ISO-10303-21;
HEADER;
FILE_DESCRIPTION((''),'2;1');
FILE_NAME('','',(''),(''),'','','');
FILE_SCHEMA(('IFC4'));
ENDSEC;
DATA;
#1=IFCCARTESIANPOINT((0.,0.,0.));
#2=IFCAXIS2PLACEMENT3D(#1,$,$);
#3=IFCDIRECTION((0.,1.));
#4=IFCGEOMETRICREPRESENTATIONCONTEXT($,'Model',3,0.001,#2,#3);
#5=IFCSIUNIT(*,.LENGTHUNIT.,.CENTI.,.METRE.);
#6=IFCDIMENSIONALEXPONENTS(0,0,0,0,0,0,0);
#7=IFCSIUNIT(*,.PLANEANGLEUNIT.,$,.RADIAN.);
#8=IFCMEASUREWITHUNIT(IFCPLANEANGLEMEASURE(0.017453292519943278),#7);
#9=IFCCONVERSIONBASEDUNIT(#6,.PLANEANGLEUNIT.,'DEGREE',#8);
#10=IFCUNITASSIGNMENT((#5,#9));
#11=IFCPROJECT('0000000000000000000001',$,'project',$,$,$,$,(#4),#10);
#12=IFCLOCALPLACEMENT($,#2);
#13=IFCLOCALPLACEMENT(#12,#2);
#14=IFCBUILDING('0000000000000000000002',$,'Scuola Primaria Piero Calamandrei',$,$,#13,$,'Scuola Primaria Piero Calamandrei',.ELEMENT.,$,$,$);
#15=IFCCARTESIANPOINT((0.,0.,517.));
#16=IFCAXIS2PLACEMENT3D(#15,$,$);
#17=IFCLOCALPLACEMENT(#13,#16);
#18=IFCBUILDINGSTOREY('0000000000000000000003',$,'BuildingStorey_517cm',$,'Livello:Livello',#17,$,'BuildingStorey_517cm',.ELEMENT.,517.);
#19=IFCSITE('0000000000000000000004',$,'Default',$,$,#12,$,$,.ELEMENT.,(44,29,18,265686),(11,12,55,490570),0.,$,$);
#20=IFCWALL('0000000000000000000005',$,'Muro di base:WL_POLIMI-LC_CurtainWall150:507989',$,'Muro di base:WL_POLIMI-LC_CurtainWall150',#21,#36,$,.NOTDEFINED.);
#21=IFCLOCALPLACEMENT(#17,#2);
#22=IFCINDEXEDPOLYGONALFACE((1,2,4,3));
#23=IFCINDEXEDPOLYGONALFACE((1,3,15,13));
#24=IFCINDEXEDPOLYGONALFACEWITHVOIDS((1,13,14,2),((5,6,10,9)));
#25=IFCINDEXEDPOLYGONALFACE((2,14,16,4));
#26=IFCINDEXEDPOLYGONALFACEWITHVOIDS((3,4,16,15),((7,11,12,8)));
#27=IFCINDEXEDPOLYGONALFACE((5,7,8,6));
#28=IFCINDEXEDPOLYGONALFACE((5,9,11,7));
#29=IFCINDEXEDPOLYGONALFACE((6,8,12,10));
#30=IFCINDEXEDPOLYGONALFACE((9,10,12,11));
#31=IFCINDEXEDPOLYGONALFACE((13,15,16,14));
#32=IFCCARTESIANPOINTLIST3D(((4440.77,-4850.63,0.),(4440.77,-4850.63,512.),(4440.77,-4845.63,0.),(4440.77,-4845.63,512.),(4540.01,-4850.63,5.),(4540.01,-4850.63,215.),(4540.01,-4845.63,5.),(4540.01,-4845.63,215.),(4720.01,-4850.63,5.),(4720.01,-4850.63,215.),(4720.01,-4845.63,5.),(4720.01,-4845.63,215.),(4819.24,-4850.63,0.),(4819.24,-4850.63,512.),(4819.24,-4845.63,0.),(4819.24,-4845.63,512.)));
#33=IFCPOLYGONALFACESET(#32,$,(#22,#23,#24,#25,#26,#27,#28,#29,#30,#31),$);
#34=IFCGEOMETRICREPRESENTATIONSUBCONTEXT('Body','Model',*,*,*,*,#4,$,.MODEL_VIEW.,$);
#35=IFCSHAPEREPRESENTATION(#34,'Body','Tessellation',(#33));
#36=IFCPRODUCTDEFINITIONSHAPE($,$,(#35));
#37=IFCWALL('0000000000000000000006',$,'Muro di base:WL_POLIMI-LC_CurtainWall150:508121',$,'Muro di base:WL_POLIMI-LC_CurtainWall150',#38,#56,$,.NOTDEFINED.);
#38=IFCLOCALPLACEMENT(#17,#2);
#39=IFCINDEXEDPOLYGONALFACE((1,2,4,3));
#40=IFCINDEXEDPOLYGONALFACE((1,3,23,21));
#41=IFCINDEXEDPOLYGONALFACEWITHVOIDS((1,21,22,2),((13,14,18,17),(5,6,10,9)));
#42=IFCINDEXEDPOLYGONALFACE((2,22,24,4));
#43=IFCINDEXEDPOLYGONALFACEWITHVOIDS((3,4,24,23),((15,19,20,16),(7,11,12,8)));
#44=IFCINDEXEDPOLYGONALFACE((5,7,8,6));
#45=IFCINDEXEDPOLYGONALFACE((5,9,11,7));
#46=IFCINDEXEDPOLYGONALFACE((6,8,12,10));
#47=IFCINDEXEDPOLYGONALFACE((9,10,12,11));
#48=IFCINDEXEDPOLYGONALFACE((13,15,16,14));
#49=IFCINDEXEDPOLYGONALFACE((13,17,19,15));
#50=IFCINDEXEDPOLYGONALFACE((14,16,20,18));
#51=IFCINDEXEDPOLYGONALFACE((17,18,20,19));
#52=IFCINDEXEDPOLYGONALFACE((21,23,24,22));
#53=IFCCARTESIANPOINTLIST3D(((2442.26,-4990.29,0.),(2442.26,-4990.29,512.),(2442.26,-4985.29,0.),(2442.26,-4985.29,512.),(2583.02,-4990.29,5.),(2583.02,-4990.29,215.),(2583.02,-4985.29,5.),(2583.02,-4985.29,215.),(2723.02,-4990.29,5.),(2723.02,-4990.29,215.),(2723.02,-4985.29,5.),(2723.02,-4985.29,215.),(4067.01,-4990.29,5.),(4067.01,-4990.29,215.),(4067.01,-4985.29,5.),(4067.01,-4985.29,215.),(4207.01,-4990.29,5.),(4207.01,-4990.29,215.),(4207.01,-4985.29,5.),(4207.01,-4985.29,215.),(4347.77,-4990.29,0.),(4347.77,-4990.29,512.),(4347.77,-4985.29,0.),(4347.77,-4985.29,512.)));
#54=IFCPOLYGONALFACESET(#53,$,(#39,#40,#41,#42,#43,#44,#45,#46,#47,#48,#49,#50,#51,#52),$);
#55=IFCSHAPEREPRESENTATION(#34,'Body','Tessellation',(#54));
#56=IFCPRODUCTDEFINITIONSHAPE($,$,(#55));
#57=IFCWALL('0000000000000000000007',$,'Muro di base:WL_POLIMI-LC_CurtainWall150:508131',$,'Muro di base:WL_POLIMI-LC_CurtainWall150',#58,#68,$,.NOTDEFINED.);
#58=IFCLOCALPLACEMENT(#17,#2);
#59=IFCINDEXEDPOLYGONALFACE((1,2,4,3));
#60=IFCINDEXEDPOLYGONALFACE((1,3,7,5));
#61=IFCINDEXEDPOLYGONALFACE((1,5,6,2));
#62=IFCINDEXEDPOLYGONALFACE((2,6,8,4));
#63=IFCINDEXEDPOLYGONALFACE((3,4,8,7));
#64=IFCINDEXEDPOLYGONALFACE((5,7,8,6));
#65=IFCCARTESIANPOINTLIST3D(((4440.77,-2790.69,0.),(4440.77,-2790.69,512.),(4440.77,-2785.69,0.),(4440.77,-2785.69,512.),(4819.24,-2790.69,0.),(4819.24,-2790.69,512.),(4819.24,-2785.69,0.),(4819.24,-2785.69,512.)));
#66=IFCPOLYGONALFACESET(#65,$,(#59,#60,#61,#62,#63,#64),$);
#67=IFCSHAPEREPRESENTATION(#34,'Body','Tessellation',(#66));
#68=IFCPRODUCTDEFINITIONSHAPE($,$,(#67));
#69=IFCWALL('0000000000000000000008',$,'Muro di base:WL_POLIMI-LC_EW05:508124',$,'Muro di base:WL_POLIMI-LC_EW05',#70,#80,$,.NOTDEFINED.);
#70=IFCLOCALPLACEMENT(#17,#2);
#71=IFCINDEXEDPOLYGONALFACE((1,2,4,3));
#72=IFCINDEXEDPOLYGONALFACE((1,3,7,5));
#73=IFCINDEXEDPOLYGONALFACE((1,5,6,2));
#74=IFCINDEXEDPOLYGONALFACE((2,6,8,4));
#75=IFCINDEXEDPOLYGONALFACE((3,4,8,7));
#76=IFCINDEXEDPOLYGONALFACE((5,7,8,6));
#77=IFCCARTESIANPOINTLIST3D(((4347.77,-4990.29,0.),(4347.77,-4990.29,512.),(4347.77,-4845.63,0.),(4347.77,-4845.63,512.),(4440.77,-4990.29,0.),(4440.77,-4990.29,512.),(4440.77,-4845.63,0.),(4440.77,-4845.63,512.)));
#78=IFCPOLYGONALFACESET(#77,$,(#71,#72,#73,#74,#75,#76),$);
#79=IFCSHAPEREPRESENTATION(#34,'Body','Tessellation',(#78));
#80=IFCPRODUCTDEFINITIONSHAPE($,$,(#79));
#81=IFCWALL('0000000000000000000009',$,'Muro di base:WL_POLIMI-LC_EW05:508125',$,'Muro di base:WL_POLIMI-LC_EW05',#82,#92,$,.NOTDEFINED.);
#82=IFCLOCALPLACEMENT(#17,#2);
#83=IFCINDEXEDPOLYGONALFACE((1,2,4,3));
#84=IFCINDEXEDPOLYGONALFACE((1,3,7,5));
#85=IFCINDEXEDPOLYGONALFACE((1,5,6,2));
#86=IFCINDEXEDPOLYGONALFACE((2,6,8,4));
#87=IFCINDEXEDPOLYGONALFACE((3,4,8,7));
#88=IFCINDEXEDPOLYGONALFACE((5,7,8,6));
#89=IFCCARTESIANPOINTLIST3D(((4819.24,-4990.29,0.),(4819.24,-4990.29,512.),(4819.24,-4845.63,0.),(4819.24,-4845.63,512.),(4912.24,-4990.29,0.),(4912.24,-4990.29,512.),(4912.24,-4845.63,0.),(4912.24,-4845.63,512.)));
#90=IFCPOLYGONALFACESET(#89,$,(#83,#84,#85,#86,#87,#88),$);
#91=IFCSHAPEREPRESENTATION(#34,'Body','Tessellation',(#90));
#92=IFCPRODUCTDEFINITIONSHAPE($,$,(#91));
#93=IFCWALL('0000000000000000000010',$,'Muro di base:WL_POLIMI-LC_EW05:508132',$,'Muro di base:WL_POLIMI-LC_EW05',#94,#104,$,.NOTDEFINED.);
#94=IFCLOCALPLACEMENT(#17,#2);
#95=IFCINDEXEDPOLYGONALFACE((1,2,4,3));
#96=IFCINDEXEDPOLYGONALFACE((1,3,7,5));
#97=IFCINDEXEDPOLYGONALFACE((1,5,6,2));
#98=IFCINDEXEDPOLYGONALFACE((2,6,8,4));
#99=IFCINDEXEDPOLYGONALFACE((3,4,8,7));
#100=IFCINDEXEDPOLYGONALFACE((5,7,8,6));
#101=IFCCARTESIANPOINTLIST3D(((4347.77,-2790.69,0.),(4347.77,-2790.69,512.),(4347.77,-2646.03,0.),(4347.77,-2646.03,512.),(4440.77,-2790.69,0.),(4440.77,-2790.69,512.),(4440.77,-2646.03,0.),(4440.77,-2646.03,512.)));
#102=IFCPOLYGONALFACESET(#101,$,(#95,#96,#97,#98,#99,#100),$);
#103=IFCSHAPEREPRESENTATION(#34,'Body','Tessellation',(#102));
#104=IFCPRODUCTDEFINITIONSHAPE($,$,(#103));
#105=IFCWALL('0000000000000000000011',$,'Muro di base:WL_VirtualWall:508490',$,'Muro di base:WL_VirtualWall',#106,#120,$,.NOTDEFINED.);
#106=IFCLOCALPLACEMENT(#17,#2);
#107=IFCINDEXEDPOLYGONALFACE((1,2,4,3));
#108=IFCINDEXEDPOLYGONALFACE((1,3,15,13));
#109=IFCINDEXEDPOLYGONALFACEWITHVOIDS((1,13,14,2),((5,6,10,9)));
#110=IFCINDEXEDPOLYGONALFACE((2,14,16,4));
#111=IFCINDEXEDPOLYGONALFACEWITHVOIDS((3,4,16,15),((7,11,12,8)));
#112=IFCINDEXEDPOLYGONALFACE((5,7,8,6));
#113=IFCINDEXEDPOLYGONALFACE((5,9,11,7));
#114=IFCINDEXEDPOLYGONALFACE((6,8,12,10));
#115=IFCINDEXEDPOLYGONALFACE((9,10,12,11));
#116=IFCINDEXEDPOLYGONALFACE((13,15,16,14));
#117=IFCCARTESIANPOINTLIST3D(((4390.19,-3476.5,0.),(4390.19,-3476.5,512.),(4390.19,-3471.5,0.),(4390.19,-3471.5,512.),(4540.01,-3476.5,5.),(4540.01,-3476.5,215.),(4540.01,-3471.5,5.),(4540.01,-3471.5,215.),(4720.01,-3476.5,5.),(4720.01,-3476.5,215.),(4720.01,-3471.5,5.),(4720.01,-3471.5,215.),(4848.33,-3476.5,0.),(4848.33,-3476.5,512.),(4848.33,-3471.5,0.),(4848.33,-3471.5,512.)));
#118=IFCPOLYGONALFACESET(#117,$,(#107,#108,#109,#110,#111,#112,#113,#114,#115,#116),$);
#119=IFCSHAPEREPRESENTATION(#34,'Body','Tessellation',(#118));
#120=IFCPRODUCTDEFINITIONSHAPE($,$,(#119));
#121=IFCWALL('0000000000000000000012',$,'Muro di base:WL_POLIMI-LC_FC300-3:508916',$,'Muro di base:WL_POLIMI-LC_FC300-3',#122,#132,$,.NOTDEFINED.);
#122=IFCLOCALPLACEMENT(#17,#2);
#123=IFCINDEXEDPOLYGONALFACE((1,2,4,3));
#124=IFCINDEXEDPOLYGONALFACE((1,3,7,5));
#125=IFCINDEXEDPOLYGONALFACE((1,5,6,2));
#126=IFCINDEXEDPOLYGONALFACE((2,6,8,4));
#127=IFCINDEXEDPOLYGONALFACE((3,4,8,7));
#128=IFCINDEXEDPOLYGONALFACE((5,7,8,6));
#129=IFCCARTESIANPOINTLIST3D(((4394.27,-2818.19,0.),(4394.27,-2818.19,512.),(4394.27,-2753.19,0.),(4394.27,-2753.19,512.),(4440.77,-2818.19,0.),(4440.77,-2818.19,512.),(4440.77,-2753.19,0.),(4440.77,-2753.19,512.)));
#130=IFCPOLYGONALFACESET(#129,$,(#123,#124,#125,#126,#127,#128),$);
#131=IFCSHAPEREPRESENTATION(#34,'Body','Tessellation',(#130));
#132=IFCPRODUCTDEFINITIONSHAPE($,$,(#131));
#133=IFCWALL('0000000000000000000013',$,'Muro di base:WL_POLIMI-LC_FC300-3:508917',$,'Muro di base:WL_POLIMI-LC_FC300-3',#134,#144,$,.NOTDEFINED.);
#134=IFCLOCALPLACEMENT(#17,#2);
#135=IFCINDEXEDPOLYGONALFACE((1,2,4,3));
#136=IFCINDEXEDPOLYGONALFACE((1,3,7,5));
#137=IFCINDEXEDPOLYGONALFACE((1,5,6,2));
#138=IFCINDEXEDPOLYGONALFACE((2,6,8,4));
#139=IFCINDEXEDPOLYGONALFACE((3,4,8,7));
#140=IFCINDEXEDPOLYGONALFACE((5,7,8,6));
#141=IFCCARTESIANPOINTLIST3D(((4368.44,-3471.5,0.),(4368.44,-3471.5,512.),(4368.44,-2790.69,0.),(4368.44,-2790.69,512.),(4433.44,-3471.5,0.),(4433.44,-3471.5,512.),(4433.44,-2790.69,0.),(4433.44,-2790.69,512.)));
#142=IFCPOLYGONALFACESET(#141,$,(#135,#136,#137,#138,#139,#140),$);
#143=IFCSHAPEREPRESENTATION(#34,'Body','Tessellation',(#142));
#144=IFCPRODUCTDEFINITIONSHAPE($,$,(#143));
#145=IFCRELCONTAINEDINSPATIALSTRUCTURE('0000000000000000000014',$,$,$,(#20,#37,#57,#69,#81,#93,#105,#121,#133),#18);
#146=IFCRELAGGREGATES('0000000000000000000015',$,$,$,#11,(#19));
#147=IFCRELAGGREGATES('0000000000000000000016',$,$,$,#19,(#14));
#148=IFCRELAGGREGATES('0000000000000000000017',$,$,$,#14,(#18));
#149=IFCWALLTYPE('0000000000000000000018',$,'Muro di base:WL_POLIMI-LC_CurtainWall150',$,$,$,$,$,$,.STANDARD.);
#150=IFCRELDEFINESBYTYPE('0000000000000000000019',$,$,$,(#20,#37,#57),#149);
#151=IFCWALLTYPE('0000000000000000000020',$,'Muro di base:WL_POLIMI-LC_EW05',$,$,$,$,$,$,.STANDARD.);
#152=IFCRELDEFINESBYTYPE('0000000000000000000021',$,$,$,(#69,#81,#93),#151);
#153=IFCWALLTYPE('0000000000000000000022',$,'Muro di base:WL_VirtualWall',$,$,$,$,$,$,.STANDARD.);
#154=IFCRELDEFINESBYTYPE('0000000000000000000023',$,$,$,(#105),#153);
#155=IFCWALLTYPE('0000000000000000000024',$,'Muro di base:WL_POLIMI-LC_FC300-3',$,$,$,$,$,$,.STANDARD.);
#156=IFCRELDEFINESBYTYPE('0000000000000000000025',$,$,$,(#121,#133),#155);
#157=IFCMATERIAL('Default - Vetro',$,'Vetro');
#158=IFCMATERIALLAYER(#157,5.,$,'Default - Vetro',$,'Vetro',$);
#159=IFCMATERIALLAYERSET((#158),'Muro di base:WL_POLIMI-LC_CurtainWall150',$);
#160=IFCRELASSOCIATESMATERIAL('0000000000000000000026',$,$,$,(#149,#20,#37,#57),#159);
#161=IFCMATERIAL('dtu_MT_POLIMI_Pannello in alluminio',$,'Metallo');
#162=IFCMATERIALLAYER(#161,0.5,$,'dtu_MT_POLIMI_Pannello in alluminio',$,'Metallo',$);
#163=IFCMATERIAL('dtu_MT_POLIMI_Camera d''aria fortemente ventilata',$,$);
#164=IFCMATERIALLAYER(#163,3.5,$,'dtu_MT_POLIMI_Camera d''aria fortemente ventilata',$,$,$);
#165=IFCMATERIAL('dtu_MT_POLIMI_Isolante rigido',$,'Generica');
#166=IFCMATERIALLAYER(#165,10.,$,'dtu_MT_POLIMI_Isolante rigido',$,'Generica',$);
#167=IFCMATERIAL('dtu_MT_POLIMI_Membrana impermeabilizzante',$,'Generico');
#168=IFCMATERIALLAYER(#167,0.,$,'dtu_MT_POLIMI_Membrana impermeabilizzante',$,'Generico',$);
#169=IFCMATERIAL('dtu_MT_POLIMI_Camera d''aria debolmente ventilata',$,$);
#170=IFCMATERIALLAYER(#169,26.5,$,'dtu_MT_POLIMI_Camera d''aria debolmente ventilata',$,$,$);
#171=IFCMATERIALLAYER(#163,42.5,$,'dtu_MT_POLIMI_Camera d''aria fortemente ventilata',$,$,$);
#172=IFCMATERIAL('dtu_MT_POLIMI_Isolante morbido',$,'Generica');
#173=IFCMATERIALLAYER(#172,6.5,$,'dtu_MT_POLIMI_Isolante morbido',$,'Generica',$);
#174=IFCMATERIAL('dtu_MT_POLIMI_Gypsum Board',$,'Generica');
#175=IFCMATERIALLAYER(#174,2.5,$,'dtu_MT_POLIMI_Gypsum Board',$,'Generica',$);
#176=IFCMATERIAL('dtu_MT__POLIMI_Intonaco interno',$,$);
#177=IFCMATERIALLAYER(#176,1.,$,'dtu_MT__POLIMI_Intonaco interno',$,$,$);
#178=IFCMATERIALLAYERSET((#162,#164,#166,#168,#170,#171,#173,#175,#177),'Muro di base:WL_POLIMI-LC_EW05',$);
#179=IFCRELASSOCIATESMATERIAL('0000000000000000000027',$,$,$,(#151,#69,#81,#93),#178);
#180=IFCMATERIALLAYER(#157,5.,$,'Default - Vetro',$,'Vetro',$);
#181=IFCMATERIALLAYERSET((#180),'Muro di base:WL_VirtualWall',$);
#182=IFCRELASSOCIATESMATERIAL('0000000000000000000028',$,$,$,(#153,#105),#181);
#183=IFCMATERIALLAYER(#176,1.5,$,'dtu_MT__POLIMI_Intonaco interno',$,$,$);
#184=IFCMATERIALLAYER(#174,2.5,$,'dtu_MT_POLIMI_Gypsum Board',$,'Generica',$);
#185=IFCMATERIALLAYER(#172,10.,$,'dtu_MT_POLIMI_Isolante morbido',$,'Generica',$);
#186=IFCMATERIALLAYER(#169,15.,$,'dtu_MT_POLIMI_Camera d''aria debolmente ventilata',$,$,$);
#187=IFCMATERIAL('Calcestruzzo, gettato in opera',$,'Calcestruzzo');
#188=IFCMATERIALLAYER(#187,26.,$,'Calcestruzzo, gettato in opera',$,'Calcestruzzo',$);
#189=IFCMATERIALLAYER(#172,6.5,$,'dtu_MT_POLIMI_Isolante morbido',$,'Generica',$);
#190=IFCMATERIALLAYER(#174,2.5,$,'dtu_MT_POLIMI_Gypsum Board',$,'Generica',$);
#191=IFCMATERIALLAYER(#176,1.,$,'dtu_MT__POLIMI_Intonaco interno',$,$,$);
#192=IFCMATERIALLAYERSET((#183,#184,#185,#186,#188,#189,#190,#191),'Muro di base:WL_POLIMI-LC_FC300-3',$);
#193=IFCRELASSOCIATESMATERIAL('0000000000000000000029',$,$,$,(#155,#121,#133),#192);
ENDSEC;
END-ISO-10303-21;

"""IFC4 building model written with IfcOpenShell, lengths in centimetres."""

from ifc_helpers import new_model, entity, si_unit, converted_unit, direction, frame, frame_2d, origin, place, context, subcontext, project, spatial, rectangle, extrude, material, layer, layer_set, layer_usage, type_object, element, save


model = new_model("IFC4")

# Units and contexts
model_context = context("Model", 3, precision=0.001, world=origin(), true_north=direction((0.0, 1.0)))
body_context = subcontext(model_context, "Body", "Model", "MODEL_VIEW")
ifc_project = project(units=[si_unit("LENGTHUNIT", "METRE", prefix="CENTI"), converted_unit("PLANEANGLEUNIT", "DEGREE", entity("IfcPlaneAngleMeasure", 0.017453292519943278), si_unit("PLANEANGLEUNIT", "RADIAN"), dimensions=[0, 0, 0, 0, 0, 0, 0])], contexts=[model_context])

# Site, building, storey
site_placement = place(None, origin())
site = spatial("IfcSite", under=ifc_project, at=site_placement, Name="Default", CompositionType="ELEMENT", RefLatitude=(44, 29, 18, 265686), RefLongitude=(11, 12, 55, 490570), RefElevation=0.0)
building_placement = place(site_placement, origin())
building = spatial("IfcBuilding", under=site, at=building_placement, Name="Scuola Primaria Piero Calamandrei", LongName="Scuola Primaria Piero Calamandrei", CompositionType="ELEMENT")
storey_placement = place(building_placement, frame((0.0, 0.0, 517.0)))
storey = spatial("IfcBuildingStorey", under=building, at=storey_placement, Name="BuildingStorey_517cm", ObjectType="Livello:Livello", LongName="BuildingStorey_517cm", CompositionType="ELEMENT", Elevation=517.0)

# Walls, openings
ifc_material_1 = material(Name="Default - Vetro", Category="Vetro")
ifc_layer_1 = layer(ifc_material_1, 5.0, Name="Default - Vetro", Category="Vetro")
ifc_layer_set_1 = layer_set([ifc_layer_1], Name="Muro di base:WL_POLIMI-LC_CurtainWall150")
ifc_layer_usage_1 = layer_usage(ifc_layer_set_1, "AXIS2", "NEGATIVE", 2.5)
wall_type_1 = type_object("IfcWallType", Name="Muro di base:WL_POLIMI-LC_CurtainWall150", PredefinedType="STANDARD", material=ifc_layer_set_1)
wall_1_placement = place(storey_placement, frame((4819.24, -4848.13, 0.0), z_axis=(0.0, 0.0, 1.0), x_axis=(-1.0, 0.0, 0.0)))
wall_1 = element("IfcWall", 1, at=wall_1_placement, inside=storey, type_object=wall_type_1, material=ifc_layer_usage_1, Name="Muro di base:WL_POLIMI-LC_CurtainWall150:507989", ObjectType="Muro di base:WL_POLIMI-LC_CurtainWall150", PredefinedType="NOTDEFINED", context=body_context, shape_type="SweptSolid", body=[
    extrude(rectangle(XDim=5.0, YDim=378.47, at=frame_2d((0.5, -37.69), x_axis=(1.0, 0.0))), frame((151.54, -0.5, 0.0), z_axis=(0.0, 0.0, 1.0), x_axis=(0.0, 1.0, 0.0)), (0.0, 0.0, 1.0), 512.0),
])
opening_1_placement = place(storey_placement, frame((4819.24, -4848.13, 0.0), z_axis=(0.0, 0.0, 1.0), x_axis=(-1.0, 0.0, 0.0)))
element("IfcOpeningElement", 2, at=opening_1_placement, cuts=wall_1, PredefinedType="OPENING", context=body_context, shape_type="SweptSolid", body=[
    extrude(rectangle(XDim=210.0, YDim=180.0, at=frame_2d((0.0, 0.0), x_axis=(1.0, 0.0))), frame((189.23, 2.5, 110.0), z_axis=(0.0, -1.0, 0.0), x_axis=(0.0, 0.0, -1.0)), (0.0, 0.0, 1.0), 5.0),
])
opening_2_placement = place(wall_1_placement, frame((99.23, -2.5, 5.0)))
element("IfcOpeningElement", 3, at=opening_2_placement, cuts=wall_1, PredefinedType="OPENING", context=body_context, shape_type="SweptSolid", body=[
    extrude(rectangle(XDim=210.0, YDim=180.0, at=frame_2d((105.0, 90.0), x_axis=(-1.0, 0.0))), frame((0.0, 0.0, 0.0), z_axis=(0.0, 1.0, 0.0), x_axis=(0.0, 0.0, 1.0)), (0.0, 0.0, 1.0), 5.0),
])
ifc_layer_usage_2 = layer_usage(ifc_layer_set_1, "AXIS2", "NEGATIVE", 2.5)
wall_2_placement = place(storey_placement, frame((4347.77, -4987.79, 0.0), z_axis=(0.0, 0.0, 1.0), x_axis=(-1.0, 0.0, 0.0)))
wall_2 = element("IfcWall", 4, at=wall_2_placement, inside=storey, type_object=wall_type_1, material=ifc_layer_usage_2, Name="Muro di base:WL_POLIMI-LC_CurtainWall150:508121", ObjectType="Muro di base:WL_POLIMI-LC_CurtainWall150", PredefinedType="NOTDEFINED", context=body_context, shape_type="SweptSolid", body=[
    extrude(rectangle(XDim=1905.52, YDim=5.0, at=frame_2d((952.76, 0.0), x_axis=(-1.0, 0.0))), origin(), (0.0, 0.0, 1.0), 512.0),
])
opening_3_placement = place(wall_2_placement, frame((1624.75, -2.5, 5.0)))
element("IfcOpeningElement", 5, at=opening_3_placement, cuts=wall_2, PredefinedType="OPENING", context=body_context, shape_type="SweptSolid", body=[
    extrude(rectangle(XDim=210.0, YDim=140.0, at=frame_2d((105.0, 70.0), x_axis=(-1.0, 0.0))), frame((0.0, 0.0, 0.0), z_axis=(0.0, 1.0, 0.0), x_axis=(0.0, 0.0, 1.0)), (0.0, 0.0, 1.0), 5.0),
])
opening_4_placement = place(wall_2_placement, frame((140.77, -2.5, 5.0)))
element("IfcOpeningElement", 6, at=opening_4_placement, cuts=wall_2, PredefinedType="OPENING", context=body_context, shape_type="SweptSolid", body=[
    extrude(rectangle(XDim=210.0, YDim=140.0, at=frame_2d((105.0, 70.0), x_axis=(-1.0, 0.0))), frame((0.0, 0.0, 0.0), z_axis=(0.0, 1.0, 0.0), x_axis=(0.0, 0.0, 1.0)), (0.0, 0.0, 1.0), 5.0),
])

# Walls
ifc_layer_usage_3 = layer_usage(ifc_layer_set_1, "AXIS2", "NEGATIVE", 2.5)
wall_3_placement = place(storey_placement, frame((4440.77, -2788.19, 0.0)))
element("IfcWall", 7, at=wall_3_placement, inside=storey, type_object=wall_type_1, material=ifc_layer_usage_3, Name="Muro di base:WL_POLIMI-LC_CurtainWall150:508131", ObjectType="Muro di base:WL_POLIMI-LC_CurtainWall150", PredefinedType="NOTDEFINED", context=body_context, shape_type="SweptSolid", body=[
    extrude(rectangle(XDim=5.0, YDim=378.47, at=frame_2d((0.0, 0.0), x_axis=(1.0, 0.0))), frame((189.23, 0.0, 0.0), z_axis=(0.0, 0.0, 1.0), x_axis=(0.0, 1.0, 0.0)), (0.0, 0.0, 1.0), 512.0),
])
ifc_material_2 = material(Name="dtu_MT_POLIMI_Pannello in alluminio", Category="Metallo")
ifc_layer_2 = layer(ifc_material_2, 0.5, Name="dtu_MT_POLIMI_Pannello in alluminio", Category="Metallo")
ifc_material_3 = material(Name="dtu_MT_POLIMI_Camera d'aria fortemente ventilata")
ifc_layer_3 = layer(ifc_material_3, 3.5, Name="dtu_MT_POLIMI_Camera d'aria fortemente ventilata")
ifc_material_4 = material(Name="dtu_MT_POLIMI_Isolante rigido", Category="Generica")
ifc_layer_4 = layer(ifc_material_4, 10.0, Name="dtu_MT_POLIMI_Isolante rigido", Category="Generica")
ifc_material_5 = material(Name="dtu_MT_POLIMI_Membrana impermeabilizzante", Category="Generico")
ifc_layer_5 = layer(ifc_material_5, 0.0, Name="dtu_MT_POLIMI_Membrana impermeabilizzante", Category="Generico")
ifc_material_6 = material(Name="dtu_MT_POLIMI_Camera d'aria debolmente ventilata")
ifc_layer_6 = layer(ifc_material_6, 26.5, Name="dtu_MT_POLIMI_Camera d'aria debolmente ventilata")
ifc_layer_7 = layer(ifc_material_3, 42.5, Name="dtu_MT_POLIMI_Camera d'aria fortemente ventilata")
ifc_material_7 = material(Name="dtu_MT_POLIMI_Isolante morbido", Category="Generica")
ifc_layer_8 = layer(ifc_material_7, 6.5, Name="dtu_MT_POLIMI_Isolante morbido", Category="Generica")
ifc_material_8 = material(Name="dtu_MT_POLIMI_Gypsum Board", Category="Generica")
ifc_layer_9 = layer(ifc_material_8, 2.5, Name="dtu_MT_POLIMI_Gypsum Board", Category="Generica")
ifc_material_9 = material(Name="dtu_MT__POLIMI_Intonaco interno")
ifc_layer_10 = layer(ifc_material_9, 1.0, Name="dtu_MT__POLIMI_Intonaco interno")
ifc_layer_set_2 = layer_set([ifc_layer_2, ifc_layer_3, ifc_layer_4, ifc_layer_5, ifc_layer_6, ifc_layer_7, ifc_layer_8, ifc_layer_9, ifc_layer_10], Name="Muro di base:WL_POLIMI-LC_EW05")
ifc_layer_usage_4 = layer_usage(ifc_layer_set_2, "AXIS2", "NEGATIVE", 46.5)
wall_type_2 = type_object("IfcWallType", Name="Muro di base:WL_POLIMI-LC_EW05", PredefinedType="STANDARD", material=ifc_layer_set_2)
wall_4_placement = place(storey_placement, frame((4394.27, -4845.63, 0.0), z_axis=(0.0, 0.0, 1.0), x_axis=(0.0, -1.0, 0.0)))
element("IfcWall", 8, at=wall_4_placement, inside=storey, type_object=wall_type_2, material=ifc_layer_usage_4, Name="Muro di base:WL_POLIMI-LC_EW05:508124", ObjectType="Muro di base:WL_POLIMI-LC_EW05", PredefinedType="NOTDEFINED", context=body_context, shape_type="SweptSolid", body=[
    extrude(rectangle(XDim=144.66, YDim=93.0, at=frame_2d((72.33, 0.0), x_axis=(-1.0, 0.0))), origin(), (0.0, 0.0, 1.0), 512.0),
])
ifc_layer_usage_5 = layer_usage(ifc_layer_set_2, "AXIS2", "NEGATIVE", 46.5)
wall_5_placement = place(storey_placement, frame((4865.74, -4990.29, 0.0), z_axis=(0.0, 0.0, 1.0), x_axis=(0.0, 1.0, 0.0)))
element("IfcWall", 9, at=wall_5_placement, inside=storey, type_object=wall_type_2, material=ifc_layer_usage_5, Name="Muro di base:WL_POLIMI-LC_EW05:508125", ObjectType="Muro di base:WL_POLIMI-LC_EW05", PredefinedType="NOTDEFINED", context=body_context, shape_type="SweptSolid", body=[
    extrude(rectangle(XDim=144.66, YDim=93.0, at=frame_2d((72.33, 0.0), x_axis=(-1.0, 0.0))), origin(), (0.0, 0.0, 1.0), 512.0),
])
ifc_layer_usage_6 = layer_usage(ifc_layer_set_2, "AXIS2", "NEGATIVE", 46.5)
wall_6_placement = place(storey_placement, frame((4394.27, -2646.03, 0.0), z_axis=(0.0, 0.0, 1.0), x_axis=(0.0, -1.0, 0.0)))
element("IfcWall", 10, at=wall_6_placement, inside=storey, type_object=wall_type_2, material=ifc_layer_usage_6, Name="Muro di base:WL_POLIMI-LC_EW05:508132", ObjectType="Muro di base:WL_POLIMI-LC_EW05", PredefinedType="NOTDEFINED", context=body_context, shape_type="SweptSolid", body=[
    extrude(rectangle(XDim=144.66, YDim=93.0, at=frame_2d((72.33, 0.0), x_axis=(-1.0, 0.0))), origin(), (0.0, 0.0, 1.0), 512.0),
])

# Wall, opening
ifc_layer_11 = layer(ifc_material_1, 5.0, Name="Default - Vetro", Category="Vetro")
ifc_layer_set_3 = layer_set([ifc_layer_11], Name="Muro di base:WL_VirtualWall")
ifc_layer_usage_7 = layer_usage(ifc_layer_set_3, "AXIS2", "NEGATIVE", 2.5)
wall_type_3 = type_object("IfcWallType", Name="Muro di base:WL_VirtualWall", PredefinedType="STANDARD", material=ifc_layer_set_3)
wall_7_placement = place(storey_placement, frame((4390.19, -3474.0, 0.0)))
wall_7 = element("IfcWall", 11, at=wall_7_placement, inside=storey, type_object=wall_type_3, material=ifc_layer_usage_7, Name="Muro di base:WL_VirtualWall:508490", ObjectType="Muro di base:WL_VirtualWall", PredefinedType="NOTDEFINED", context=body_context, shape_type="SweptSolid", body=[
    extrude(rectangle(XDim=458.14, YDim=5.0, at=frame_2d((229.07, 0.0), x_axis=(-1.0, 0.0))), origin(), (0.0, 0.0, 1.0), 512.0),
])
opening_5_placement = place(wall_7_placement, frame((149.82, -2.5, 5.0)))
element("IfcOpeningElement", 12, at=opening_5_placement, cuts=wall_7, PredefinedType="OPENING", context=body_context, shape_type="SweptSolid", body=[
    extrude(rectangle(XDim=210.0, YDim=180.0, at=frame_2d((105.0, 90.0), x_axis=(1.0, 0.0))), frame((0.0, 0.0, 0.0), z_axis=(0.0, 1.0, 0.0), x_axis=(0.0, 0.0, 1.0)), (0.0, 0.0, 1.0), 5.0),
])

# Walls
ifc_layer_12 = layer(ifc_material_9, 1.5, Name="dtu_MT__POLIMI_Intonaco interno")
ifc_layer_13 = layer(ifc_material_8, 2.5, Name="dtu_MT_POLIMI_Gypsum Board", Category="Generica")
ifc_layer_14 = layer(ifc_material_7, 10.0, Name="dtu_MT_POLIMI_Isolante morbido", Category="Generica")
ifc_layer_15 = layer(ifc_material_6, 15.0, Name="dtu_MT_POLIMI_Camera d'aria debolmente ventilata")
ifc_material_10 = material(Name="Calcestruzzo, gettato in opera", Category="Calcestruzzo")
ifc_layer_16 = layer(ifc_material_10, 26.0, Name="Calcestruzzo, gettato in opera", Category="Calcestruzzo")
ifc_layer_17 = layer(ifc_material_7, 6.5, Name="dtu_MT_POLIMI_Isolante morbido", Category="Generica")
ifc_layer_18 = layer(ifc_material_8, 2.5, Name="dtu_MT_POLIMI_Gypsum Board", Category="Generica")
ifc_layer_19 = layer(ifc_material_9, 1.0, Name="dtu_MT__POLIMI_Intonaco interno")
ifc_layer_set_4 = layer_set([ifc_layer_12, ifc_layer_13, ifc_layer_14, ifc_layer_15, ifc_layer_16, ifc_layer_17, ifc_layer_18, ifc_layer_19], Name="Muro di base:WL_POLIMI-LC_FC300-3")
ifc_layer_usage_8 = layer_usage(ifc_layer_set_4, "AXIS2", "NEGATIVE", 32.5)
wall_type_4 = type_object("IfcWallType", Name="Muro di base:WL_POLIMI-LC_FC300-3", PredefinedType="STANDARD", material=ifc_layer_set_4)
wall_8_placement = place(storey_placement, frame((4394.27, -2785.69, 0.0)))
element("IfcWall", 13, at=wall_8_placement, inside=storey, type_object=wall_type_4, material=ifc_layer_usage_8, Name="Muro di base:WL_POLIMI-LC_FC300-3:508916", ObjectType="Muro di base:WL_POLIMI-LC_FC300-3", PredefinedType="NOTDEFINED", context=body_context, shape_type="SweptSolid", body=[
    extrude(rectangle(XDim=46.5, YDim=65.0, at=frame_2d((23.25, 0.0), x_axis=(-1.0, 0.0))), origin(), (0.0, 0.0, 1.0), 512.0),
])
ifc_layer_usage_9 = layer_usage(ifc_layer_set_4, "AXIS2", "NEGATIVE", 32.5)
wall_9_placement = place(storey_placement, frame((4400.94, -3471.5, 0.0), z_axis=(0.0, 0.0, 1.0), x_axis=(0.0, 1.0, 0.0)))
element("IfcWall", 14, at=wall_9_placement, inside=storey, type_object=wall_type_4, material=ifc_layer_usage_9, Name="Muro di base:WL_POLIMI-LC_FC300-3:508917", ObjectType="Muro di base:WL_POLIMI-LC_FC300-3", PredefinedType="NOTDEFINED", context=body_context, shape_type="SweptSolid", body=[
    extrude(rectangle(XDim=680.81, YDim=65.0, at=frame_2d((340.41, 0.0), x_axis=(-1.0, 0.0))), origin(), (0.0, 0.0, 1.0), 512.0),
])

save(model, "model.ifc")
